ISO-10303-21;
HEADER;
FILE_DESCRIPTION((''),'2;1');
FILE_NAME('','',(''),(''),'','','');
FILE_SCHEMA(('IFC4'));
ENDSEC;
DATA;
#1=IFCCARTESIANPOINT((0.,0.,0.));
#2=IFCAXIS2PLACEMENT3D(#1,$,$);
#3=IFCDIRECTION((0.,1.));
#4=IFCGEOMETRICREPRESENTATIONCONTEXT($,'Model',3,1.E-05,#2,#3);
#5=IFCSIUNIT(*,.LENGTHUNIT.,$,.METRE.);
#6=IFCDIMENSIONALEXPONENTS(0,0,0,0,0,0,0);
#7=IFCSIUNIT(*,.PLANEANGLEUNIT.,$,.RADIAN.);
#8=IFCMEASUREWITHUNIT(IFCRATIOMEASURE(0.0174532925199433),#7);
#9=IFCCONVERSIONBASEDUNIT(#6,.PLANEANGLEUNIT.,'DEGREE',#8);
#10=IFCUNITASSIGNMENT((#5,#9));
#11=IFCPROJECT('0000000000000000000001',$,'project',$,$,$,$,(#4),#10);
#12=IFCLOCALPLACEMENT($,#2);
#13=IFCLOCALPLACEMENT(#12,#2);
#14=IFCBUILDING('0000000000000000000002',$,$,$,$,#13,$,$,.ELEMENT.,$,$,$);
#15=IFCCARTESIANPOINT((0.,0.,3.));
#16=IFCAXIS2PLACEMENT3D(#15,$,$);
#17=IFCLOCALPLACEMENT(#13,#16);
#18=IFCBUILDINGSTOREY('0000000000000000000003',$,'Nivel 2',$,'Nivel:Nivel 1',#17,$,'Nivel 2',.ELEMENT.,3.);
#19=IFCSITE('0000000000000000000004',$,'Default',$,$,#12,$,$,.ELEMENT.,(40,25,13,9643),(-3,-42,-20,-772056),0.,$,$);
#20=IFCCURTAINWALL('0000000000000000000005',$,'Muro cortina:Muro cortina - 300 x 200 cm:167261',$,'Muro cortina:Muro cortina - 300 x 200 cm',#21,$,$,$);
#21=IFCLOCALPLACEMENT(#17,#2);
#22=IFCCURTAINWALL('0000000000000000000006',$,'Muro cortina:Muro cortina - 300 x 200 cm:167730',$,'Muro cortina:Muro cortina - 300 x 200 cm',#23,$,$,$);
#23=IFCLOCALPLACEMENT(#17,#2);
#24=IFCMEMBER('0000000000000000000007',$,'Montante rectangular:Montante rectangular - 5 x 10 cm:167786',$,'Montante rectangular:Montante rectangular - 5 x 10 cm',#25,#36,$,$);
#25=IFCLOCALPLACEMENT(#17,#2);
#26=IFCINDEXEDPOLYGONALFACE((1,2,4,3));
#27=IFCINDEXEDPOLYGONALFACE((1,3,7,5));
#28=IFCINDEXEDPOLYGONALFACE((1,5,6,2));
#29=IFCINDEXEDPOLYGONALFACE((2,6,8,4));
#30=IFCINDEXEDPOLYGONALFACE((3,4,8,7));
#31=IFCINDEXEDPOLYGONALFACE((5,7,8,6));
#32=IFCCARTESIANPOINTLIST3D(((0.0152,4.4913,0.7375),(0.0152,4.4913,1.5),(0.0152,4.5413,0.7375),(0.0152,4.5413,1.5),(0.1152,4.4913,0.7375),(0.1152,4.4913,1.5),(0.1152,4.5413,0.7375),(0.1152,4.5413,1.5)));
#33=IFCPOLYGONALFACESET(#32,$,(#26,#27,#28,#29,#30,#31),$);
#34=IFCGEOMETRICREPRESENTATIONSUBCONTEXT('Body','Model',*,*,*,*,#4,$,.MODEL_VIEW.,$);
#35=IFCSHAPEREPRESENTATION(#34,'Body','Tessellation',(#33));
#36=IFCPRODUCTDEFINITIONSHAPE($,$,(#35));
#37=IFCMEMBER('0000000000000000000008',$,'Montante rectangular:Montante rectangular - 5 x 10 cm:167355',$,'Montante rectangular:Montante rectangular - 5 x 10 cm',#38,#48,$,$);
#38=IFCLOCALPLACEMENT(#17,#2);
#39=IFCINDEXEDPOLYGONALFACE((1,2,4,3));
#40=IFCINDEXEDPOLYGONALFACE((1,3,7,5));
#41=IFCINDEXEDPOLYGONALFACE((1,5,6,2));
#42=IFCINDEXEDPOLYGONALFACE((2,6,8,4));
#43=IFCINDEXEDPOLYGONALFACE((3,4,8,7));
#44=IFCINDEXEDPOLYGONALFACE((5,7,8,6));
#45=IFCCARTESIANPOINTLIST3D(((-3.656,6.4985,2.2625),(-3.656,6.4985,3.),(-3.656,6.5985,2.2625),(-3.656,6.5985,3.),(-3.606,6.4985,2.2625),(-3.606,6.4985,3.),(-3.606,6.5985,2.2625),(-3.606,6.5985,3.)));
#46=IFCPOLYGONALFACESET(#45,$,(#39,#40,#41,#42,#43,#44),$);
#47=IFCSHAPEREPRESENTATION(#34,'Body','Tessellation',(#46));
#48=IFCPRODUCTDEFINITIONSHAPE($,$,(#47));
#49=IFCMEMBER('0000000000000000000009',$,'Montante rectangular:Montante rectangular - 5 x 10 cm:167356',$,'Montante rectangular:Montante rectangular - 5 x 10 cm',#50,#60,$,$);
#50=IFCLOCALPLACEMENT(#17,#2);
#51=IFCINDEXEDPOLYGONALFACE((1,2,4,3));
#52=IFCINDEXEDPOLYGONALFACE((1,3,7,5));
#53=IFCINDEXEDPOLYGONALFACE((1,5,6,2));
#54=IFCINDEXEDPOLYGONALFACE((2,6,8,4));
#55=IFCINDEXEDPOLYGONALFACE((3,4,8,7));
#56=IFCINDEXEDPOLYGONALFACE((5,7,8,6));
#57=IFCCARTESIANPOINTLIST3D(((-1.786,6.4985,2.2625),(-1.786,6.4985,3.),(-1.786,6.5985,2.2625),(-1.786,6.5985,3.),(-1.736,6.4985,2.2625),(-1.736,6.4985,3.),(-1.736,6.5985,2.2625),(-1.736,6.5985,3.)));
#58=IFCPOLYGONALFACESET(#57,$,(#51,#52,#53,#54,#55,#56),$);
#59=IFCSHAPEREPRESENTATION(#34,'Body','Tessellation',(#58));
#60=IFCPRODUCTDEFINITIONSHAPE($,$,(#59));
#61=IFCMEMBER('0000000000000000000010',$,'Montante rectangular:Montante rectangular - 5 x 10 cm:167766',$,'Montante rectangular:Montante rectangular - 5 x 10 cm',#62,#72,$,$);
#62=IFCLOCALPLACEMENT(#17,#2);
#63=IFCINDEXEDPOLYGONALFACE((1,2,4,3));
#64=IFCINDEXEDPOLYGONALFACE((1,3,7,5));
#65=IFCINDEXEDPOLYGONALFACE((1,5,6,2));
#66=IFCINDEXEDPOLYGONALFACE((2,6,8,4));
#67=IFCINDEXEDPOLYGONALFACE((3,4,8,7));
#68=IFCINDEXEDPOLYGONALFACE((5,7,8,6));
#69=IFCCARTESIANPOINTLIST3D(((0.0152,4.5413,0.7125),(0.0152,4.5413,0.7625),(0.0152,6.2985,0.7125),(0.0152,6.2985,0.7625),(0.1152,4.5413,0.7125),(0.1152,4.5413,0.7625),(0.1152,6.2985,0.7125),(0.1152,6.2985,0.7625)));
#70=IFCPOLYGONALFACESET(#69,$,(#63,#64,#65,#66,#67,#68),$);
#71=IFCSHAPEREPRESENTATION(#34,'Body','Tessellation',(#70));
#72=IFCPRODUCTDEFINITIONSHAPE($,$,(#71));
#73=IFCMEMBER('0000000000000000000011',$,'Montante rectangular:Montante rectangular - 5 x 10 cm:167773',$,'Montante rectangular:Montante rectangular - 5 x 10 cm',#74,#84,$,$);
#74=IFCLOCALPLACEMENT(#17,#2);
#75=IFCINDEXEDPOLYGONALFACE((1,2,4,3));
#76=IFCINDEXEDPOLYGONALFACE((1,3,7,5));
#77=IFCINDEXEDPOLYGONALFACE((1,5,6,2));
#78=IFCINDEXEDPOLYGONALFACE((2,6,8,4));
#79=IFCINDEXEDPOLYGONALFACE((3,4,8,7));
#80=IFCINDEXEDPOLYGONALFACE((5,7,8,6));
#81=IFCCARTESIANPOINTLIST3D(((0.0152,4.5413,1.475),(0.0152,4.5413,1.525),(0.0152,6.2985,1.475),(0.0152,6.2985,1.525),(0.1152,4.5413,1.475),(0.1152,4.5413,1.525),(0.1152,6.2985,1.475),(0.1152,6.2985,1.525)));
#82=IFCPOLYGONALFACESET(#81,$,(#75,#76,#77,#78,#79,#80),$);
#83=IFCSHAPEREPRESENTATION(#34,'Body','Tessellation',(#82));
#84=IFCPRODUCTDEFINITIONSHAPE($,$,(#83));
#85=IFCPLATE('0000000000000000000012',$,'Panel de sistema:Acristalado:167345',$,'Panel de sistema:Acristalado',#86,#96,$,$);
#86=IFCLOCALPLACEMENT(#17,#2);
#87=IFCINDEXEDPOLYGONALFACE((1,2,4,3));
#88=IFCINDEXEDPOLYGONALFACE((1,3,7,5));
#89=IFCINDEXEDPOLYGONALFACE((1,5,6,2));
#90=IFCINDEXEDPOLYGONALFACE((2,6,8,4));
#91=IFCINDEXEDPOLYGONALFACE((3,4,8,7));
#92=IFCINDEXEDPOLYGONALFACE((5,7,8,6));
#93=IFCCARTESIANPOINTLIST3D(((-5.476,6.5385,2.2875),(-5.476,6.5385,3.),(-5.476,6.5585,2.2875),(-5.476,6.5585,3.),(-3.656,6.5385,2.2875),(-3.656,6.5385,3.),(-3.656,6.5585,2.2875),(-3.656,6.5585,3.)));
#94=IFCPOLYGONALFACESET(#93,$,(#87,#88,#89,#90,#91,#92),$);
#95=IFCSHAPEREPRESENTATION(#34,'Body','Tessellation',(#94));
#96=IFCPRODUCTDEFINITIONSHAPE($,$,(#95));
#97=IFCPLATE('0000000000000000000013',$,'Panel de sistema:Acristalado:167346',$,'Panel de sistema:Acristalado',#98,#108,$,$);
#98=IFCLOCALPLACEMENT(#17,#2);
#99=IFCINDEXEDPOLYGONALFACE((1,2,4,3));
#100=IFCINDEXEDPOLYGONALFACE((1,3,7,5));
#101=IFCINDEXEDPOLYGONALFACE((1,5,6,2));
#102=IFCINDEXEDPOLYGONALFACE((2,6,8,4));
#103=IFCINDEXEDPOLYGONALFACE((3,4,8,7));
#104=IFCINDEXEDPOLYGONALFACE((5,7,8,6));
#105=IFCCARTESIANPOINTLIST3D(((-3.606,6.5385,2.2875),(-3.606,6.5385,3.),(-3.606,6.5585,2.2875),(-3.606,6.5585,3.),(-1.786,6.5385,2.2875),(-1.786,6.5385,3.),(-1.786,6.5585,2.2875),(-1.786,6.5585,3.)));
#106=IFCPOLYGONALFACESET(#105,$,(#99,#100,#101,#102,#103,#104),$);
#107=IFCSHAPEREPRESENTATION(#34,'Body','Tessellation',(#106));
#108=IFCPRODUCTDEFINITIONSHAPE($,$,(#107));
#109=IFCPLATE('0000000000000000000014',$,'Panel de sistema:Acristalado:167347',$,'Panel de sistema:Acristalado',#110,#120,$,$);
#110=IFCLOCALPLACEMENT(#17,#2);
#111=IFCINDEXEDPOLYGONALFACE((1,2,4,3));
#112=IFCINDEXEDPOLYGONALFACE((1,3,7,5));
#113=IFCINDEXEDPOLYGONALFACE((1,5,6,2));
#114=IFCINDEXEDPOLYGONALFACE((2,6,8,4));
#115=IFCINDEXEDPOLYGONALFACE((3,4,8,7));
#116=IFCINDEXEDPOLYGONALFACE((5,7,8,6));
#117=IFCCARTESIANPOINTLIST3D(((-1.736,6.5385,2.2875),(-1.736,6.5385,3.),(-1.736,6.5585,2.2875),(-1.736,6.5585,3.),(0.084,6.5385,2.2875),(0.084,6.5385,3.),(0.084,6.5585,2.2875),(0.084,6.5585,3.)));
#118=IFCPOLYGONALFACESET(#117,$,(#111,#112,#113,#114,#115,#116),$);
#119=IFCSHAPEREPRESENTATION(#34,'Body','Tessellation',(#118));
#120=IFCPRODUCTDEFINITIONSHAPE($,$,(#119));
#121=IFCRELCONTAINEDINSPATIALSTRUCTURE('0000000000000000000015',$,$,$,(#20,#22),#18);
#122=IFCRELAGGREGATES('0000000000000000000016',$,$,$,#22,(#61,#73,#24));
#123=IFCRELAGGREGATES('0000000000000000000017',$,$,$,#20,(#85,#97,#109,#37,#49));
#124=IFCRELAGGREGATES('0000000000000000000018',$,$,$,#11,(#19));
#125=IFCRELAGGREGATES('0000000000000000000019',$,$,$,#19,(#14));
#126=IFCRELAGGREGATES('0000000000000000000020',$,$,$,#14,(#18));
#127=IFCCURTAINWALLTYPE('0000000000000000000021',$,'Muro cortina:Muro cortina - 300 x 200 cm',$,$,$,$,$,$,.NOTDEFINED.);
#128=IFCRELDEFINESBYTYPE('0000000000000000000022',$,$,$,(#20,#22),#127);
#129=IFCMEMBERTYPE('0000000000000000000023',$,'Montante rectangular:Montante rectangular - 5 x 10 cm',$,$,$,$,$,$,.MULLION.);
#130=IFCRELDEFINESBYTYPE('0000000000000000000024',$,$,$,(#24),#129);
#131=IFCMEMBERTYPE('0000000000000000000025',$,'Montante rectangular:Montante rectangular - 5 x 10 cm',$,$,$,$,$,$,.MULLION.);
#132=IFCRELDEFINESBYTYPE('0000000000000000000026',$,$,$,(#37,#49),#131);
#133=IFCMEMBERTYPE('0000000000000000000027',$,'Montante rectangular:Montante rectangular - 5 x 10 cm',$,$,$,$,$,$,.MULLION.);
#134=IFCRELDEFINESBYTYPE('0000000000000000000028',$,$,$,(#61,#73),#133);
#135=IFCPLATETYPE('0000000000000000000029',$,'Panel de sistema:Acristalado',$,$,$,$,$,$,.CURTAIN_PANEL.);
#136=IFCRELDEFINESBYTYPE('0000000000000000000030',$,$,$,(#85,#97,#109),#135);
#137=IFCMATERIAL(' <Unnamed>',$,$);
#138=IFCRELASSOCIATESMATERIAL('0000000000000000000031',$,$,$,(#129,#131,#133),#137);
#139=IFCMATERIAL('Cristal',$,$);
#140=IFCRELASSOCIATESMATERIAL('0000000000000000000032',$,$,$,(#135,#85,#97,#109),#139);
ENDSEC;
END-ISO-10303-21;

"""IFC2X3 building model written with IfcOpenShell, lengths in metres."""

from ifc_helpers import new_model, entity, si_unit, converted_unit, direction, frame, origin, origin_2d_with_axis, place, context, subcontext, project, spatial, rectangle, extrude, source, transform, mapped, material, type_object, type_shapes, element, aggregate, save


model = new_model("IFC2X3")

# Units and contexts
model_context = context("Model", 3, precision=1e-05, world=origin(), true_north=direction((0.0, 1.0)))
body_context = subcontext(model_context, "Body", "Model", "MODEL_VIEW")
ifc_project = project(units=[si_unit("LENGTHUNIT", "METRE"), converted_unit("PLANEANGLEUNIT", "DEGREE", entity("IfcRatioMeasure", 0.0174532925199433), si_unit("PLANEANGLEUNIT", "RADIAN"), dimensions=[0, 0, 0, 0, 0, 0, 0])], contexts=[model_context])

# Site, building, storey
site_placement = place(None, origin())
site = spatial("IfcSite", under=ifc_project, at=site_placement, Name="Default", CompositionType="ELEMENT", RefLatitude=(40, 25, 13, 9643), RefLongitude=(-3, -42, -20, -772056), RefElevation=0.0)
building_placement = place(site_placement, origin())
building = spatial("IfcBuilding", under=site, at=building_placement, CompositionType="ELEMENT")
storey_placement = place(building_placement, frame((0.0, 0.0, 3.0)))
storey = spatial("IfcBuildingStorey", under=building, at=storey_placement, Name="Nivel 2", ObjectType="Nivel:Nivel 1", LongName="Nivel 2", CompositionType="ELEMENT", Elevation=3.0)

# Curtain wall
curtain_wall_type = type_object("IfcCurtainWallType", Name="Muro cortina:Muro cortina - 300 x 200 cm", PredefinedType="NOTDEFINED")
curtain_wall_1_placement = place(storey_placement, frame((0.0, 0.0, -3.0)))
curtain_wall_1 = element("IfcCurtainWall", 1, at=curtain_wall_1_placement, inside=storey, type_object=curtain_wall_type, Name="Muro cortina:Muro cortina - 300 x 200 cm:167261", ObjectType="Muro cortina:Muro cortina - 300 x 200 cm")
ifc_material_1 = material(Name=" <Unnamed>")

# Curtain wall
curtain_wall_2_placement = place(storey_placement, frame((0.0, 0.0, -3.0)))
curtain_wall_2 = element("IfcCurtainWall", 2, at=curtain_wall_2_placement, inside=storey, type_object=curtain_wall_type, Name="Muro cortina:Muro cortina - 300 x 200 cm:167730", ObjectType="Muro cortina:Muro cortina - 300 x 200 cm")

# Members
member_type_1 = type_object("IfcMemberType", Name="Montante rectangular:Montante rectangular - 5 x 10 cm", PredefinedType="MULLION", material=ifc_material_1)
shared_shape_1 = source(origin(), body_context, "Body", "SweptSolid", [
    extrude(rectangle(XDim=0.1, YDim=0.05, at=origin_2d_with_axis()), frame((0.0, 0.0, -0.7625), z_axis=(0.0, 0.0, 1.0), x_axis=(0.0, -1.0, 0.0)), (0.0, 0.0, 1.0), 0.7625),
])
type_shapes(member_type_1, [shared_shape_1])
member_1_placement = place(storey_placement, frame((0.0652, 4.5163, 0.7375), z_axis=(0.0, 0.0, -1.0), x_axis=(0.0, -1.0, 0.0)))
member_1 = element("IfcMember", 3, at=member_1_placement, type_object=member_type_1, Name="Montante rectangular:Montante rectangular - 5 x 10 cm:167786", ObjectType="Montante rectangular:Montante rectangular - 5 x 10 cm", context=body_context, shape_type="MappedRepresentation", body=[
    mapped(shared_shape_1, transform((0.0, 0.0, 0.0), scale=1.0)),
])
member_type_2 = type_object("IfcMemberType", Name="Montante rectangular:Montante rectangular - 5 x 10 cm", PredefinedType="MULLION", material=ifc_material_1)
shared_shape_2 = source(origin(), body_context, "Body", "SweptSolid", [
    extrude(rectangle(XDim=0.1, YDim=0.05, at=origin_2d_with_axis()), frame((0.0, 0.0, -0.7375), z_axis=(0.0, 0.0, 1.0), x_axis=(0.0, -1.0, 0.0)), (0.0, 0.0, 1.0), 0.7375),
])
type_shapes(member_type_2, [shared_shape_2])
member_2_placement = place(storey_placement, frame((-3.631, 6.5485, 2.2625), z_axis=(0.0, 0.0, -1.0), x_axis=(1.0, 0.0, 0.0)))
member_2 = element("IfcMember", 4, at=member_2_placement, type_object=member_type_2, Name="Montante rectangular:Montante rectangular - 5 x 10 cm:167355", ObjectType="Montante rectangular:Montante rectangular - 5 x 10 cm", context=body_context, shape_type="MappedRepresentation", body=[
    mapped(shared_shape_2, transform((0.0, 0.0, 0.0), scale=1.0)),
])
member_3_placement = place(storey_placement, frame((-1.761, 6.5485, 2.2625), z_axis=(0.0, 0.0, -1.0), x_axis=(1.0, 0.0, 0.0)))
member_3 = element("IfcMember", 5, at=member_3_placement, type_object=member_type_2, Name="Montante rectangular:Montante rectangular - 5 x 10 cm:167356", ObjectType="Montante rectangular:Montante rectangular - 5 x 10 cm", context=body_context, shape_type="MappedRepresentation", body=[
    mapped(shared_shape_2, transform((0.0, 0.0, 0.0), scale=1.0)),
])
member_type_3 = type_object("IfcMemberType", Name="Montante rectangular:Montante rectangular - 5 x 10 cm", PredefinedType="MULLION", material=ifc_material_1)
shared_shape_3 = source(origin(), body_context, "Body", "SweptSolid", [
    extrude(rectangle(XDim=0.1, YDim=0.05, at=origin_2d_with_axis()), frame((0.0, 0.0, -1.7571), z_axis=(0.0, 0.0, 1.0), x_axis=(0.0, -1.0, 0.0)), (0.0, 0.0, 1.0), 1.7571),
])
type_shapes(member_type_3, [shared_shape_3])
member_4_placement = place(storey_placement, frame((0.0652, 4.5413, 0.7375), z_axis=(0.0, -1.0, 0.0), x_axis=(0.0, 0.0, 1.0)))
member_4 = element("IfcMember", 6, at=member_4_placement, type_object=member_type_3, Name="Montante rectangular:Montante rectangular - 5 x 10 cm:167766", ObjectType="Montante rectangular:Montante rectangular - 5 x 10 cm", context=body_context, shape_type="MappedRepresentation", body=[
    mapped(shared_shape_3, transform((0.0, 0.0, 0.0), scale=1.0)),
])
member_5_placement = place(storey_placement, frame((0.0652, 4.5413, 1.5), z_axis=(0.0, -1.0, 0.0), x_axis=(0.0, 0.0, 1.0)))
member_5 = element("IfcMember", 7, at=member_5_placement, type_object=member_type_3, Name="Montante rectangular:Montante rectangular - 5 x 10 cm:167773", ObjectType="Montante rectangular:Montante rectangular - 5 x 10 cm", context=body_context, shape_type="MappedRepresentation", body=[
    mapped(shared_shape_3, transform((0.0, 0.0, 0.0), scale=1.0)),
])
aggregate(curtain_wall_2, [member_4, member_5, member_1])

# Plates
ifc_material_2 = material(Name="Cristal")
plate_type = type_object("IfcPlateType", Name="Panel de sistema:Acristalado", PredefinedType="CURTAIN_PANEL", material=ifc_material_2)
shared_shape_4 = source(origin(), body_context, "Body", "SweptSolid", [
    extrude(rectangle(XDim=0.02, YDim=1.82, at=origin_2d_with_axis()), frame((0.0, 0.0, 0.0), z_axis=(0.0, 0.0, 1.0), x_axis=(0.0, 1.0, 0.0)), (0.0, 0.0, 1.0), 0.7125),
])
type_shapes(plate_type, [shared_shape_4])
plate_1_placement = place(curtain_wall_1_placement, frame((-4.566, 6.5485, 5.2875)))
plate_1 = element("IfcPlate", 8, at=plate_1_placement, type_object=plate_type, material=ifc_material_2, Name="Panel de sistema:Acristalado:167345", ObjectType="Panel de sistema:Acristalado", context=body_context, shape_type="MappedRepresentation", body=[
    mapped(shared_shape_4, transform((0.0, 0.0, 0.0), scale=1.0)),
])
plate_2_placement = place(curtain_wall_1_placement, frame((-2.696, 6.5485, 5.2875)))
plate_2 = element("IfcPlate", 9, at=plate_2_placement, type_object=plate_type, material=ifc_material_2, Name="Panel de sistema:Acristalado:167346", ObjectType="Panel de sistema:Acristalado", context=body_context, shape_type="MappedRepresentation", body=[
    mapped(shared_shape_4, transform((0.0, 0.0, 0.0), scale=1.0)),
])
plate_3_placement = place(curtain_wall_1_placement, frame((-0.826, 6.5485, 5.2875)))
plate_3 = element("IfcPlate", 10, at=plate_3_placement, type_object=plate_type, material=ifc_material_2, Name="Panel de sistema:Acristalado:167347", ObjectType="Panel de sistema:Acristalado", context=body_context, shape_type="MappedRepresentation", body=[
    mapped(shared_shape_4, transform((0.0, 0.0, 0.0), scale=1.0)),
])
aggregate(curtain_wall_1, [plate_1, plate_2, plate_3, member_2, member_3])

save(model, "model.ifc")
